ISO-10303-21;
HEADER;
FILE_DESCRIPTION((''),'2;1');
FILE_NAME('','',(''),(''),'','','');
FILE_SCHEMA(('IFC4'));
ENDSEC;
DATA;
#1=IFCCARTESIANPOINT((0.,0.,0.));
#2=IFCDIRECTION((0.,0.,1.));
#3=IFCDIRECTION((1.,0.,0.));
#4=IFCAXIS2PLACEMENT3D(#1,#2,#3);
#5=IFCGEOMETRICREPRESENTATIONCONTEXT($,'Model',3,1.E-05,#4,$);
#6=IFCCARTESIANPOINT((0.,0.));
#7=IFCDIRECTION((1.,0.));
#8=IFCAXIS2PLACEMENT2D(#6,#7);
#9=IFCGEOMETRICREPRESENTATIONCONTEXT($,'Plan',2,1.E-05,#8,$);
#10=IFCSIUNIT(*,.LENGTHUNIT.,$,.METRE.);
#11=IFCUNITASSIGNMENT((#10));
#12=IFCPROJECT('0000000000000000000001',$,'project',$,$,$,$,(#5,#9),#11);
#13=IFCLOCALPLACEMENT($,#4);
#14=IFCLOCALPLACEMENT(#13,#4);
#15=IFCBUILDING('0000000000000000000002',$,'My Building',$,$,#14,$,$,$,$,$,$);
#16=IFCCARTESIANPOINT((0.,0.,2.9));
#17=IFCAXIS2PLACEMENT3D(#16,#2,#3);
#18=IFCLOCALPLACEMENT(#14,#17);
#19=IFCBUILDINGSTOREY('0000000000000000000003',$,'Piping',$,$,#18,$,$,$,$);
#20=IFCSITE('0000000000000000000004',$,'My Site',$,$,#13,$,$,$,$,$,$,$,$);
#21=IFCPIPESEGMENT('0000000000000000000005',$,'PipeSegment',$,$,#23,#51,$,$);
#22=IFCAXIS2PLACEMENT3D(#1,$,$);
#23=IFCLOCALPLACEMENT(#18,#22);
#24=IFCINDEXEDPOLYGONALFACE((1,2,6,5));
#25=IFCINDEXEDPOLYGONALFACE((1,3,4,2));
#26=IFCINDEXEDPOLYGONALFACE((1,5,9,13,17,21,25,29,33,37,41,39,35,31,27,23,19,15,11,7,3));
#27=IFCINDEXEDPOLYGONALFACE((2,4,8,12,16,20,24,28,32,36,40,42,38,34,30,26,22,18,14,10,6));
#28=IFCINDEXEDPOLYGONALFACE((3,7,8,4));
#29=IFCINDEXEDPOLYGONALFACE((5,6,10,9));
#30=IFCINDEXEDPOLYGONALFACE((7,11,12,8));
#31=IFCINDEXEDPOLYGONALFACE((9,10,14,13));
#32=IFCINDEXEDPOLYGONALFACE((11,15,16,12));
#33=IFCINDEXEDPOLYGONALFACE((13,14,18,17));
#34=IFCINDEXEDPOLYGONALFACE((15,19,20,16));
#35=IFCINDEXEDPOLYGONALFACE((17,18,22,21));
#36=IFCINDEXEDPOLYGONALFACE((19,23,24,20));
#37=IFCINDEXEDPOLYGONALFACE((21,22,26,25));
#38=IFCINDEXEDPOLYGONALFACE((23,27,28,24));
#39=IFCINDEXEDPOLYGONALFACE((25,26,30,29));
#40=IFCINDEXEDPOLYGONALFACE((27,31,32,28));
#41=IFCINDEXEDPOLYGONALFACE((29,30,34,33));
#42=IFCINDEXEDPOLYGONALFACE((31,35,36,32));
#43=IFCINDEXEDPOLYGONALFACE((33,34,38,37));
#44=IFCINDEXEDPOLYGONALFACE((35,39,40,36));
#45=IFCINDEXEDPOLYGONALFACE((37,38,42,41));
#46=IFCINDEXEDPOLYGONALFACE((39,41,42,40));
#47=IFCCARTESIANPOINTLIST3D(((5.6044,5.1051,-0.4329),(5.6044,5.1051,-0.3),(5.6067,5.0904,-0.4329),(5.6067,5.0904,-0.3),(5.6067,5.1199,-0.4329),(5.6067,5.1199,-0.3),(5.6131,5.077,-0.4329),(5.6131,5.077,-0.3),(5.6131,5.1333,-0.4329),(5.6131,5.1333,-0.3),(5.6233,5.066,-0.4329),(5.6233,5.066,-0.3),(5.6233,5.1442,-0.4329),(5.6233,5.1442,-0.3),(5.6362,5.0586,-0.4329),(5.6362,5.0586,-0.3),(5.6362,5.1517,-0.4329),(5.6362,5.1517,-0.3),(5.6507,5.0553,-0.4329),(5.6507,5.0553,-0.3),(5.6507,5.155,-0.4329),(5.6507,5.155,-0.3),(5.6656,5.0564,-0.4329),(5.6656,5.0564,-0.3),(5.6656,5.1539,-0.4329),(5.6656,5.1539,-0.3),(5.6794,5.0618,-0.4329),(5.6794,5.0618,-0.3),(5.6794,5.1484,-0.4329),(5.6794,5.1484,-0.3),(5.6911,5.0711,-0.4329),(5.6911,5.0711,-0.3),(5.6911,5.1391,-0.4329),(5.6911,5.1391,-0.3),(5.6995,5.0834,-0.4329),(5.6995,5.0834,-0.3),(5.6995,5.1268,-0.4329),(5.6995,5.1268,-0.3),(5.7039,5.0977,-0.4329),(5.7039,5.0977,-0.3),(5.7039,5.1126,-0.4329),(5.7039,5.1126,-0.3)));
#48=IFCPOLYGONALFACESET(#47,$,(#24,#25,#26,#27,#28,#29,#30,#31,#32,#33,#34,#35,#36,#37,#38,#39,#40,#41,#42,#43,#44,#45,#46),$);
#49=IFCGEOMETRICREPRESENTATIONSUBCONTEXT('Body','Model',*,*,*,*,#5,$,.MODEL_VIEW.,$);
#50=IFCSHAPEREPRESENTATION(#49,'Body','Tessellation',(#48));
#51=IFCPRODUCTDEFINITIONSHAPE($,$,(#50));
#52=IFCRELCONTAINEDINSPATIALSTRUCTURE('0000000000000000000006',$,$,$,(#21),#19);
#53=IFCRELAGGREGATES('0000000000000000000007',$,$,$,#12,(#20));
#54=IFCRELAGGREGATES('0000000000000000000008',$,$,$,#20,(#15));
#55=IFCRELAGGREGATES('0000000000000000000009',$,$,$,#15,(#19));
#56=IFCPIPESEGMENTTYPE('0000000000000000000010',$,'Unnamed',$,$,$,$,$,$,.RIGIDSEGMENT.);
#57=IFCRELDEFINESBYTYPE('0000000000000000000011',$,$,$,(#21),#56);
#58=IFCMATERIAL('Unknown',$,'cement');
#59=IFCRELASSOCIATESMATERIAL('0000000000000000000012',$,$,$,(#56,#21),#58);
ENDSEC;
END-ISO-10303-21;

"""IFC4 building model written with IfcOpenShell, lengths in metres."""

from ifc_helpers import new_model, si_unit, frame, origin_with_axes, origin_2d_with_axis, place, context, subcontext, project, spatial, circle, extrude, material, material_profile, profile_set, profile_usage, type_object, element, save


model = new_model("IFC4")

# Units and contexts
model_context = context("Model", 3, precision=1e-05, world=origin_with_axes())
plan_context = context("Plan", 2, precision=1e-05, world=origin_2d_with_axis())
body_context = subcontext(model_context, "Body", "Model", "MODEL_VIEW")
ifc_project = project(units=[si_unit("LENGTHUNIT", "METRE")], contexts=[model_context, plan_context])

# Site, building, storey
site_placement = place(None, origin_with_axes())
site = spatial("IfcSite", under=ifc_project, at=site_placement, Name="My Site")
building_placement = place(site_placement, origin_with_axes())
building = spatial("IfcBuilding", under=site, at=building_placement, Name="My Building")
storey_placement = place(building_placement, frame((0.0, 0.0, 2.9), z_axis=(0.0, 0.0, 1.0), x_axis=(1.0, 0.0, 0.0)))
storey = spatial("IfcBuildingStorey", under=building, at=storey_placement, Name="Piping")

# Pipe segment
ifc_material = material(Name="Unknown", Category="cement")
ifc_material_profile_1 = material_profile(ifc_material, circle(Radius=0.05))
ifc_profile_set_1 = profile_set([ifc_material_profile_1])
pipe_segment_type = type_object("IfcPipeSegmentType", Name="Unnamed", PredefinedType="RIGIDSEGMENT", material=ifc_profile_set_1)
ifc_profile_usage_1 = profile_usage(ifc_profile_set_1, cardinal=5)
pipe_segment_1_placement = place(storey_placement, frame((5.6544, 5.1051, -0.4329), z_axis=(0.0, 0.0, 1.0), x_axis=(-1.0, 0.0, 0.0)))
element("IfcPipeSegment", 1, at=pipe_segment_1_placement, inside=storey, type_object=pipe_segment_type, material=ifc_profile_usage_1, Name="PipeSegment", context=body_context, shape_type="SweptSolid", body=[
    extrude(circle(Radius=0.05), origin_with_axes(), (0.0, 0.0, 1.0), 0.1329),
])

save(model, "model.ifc")
